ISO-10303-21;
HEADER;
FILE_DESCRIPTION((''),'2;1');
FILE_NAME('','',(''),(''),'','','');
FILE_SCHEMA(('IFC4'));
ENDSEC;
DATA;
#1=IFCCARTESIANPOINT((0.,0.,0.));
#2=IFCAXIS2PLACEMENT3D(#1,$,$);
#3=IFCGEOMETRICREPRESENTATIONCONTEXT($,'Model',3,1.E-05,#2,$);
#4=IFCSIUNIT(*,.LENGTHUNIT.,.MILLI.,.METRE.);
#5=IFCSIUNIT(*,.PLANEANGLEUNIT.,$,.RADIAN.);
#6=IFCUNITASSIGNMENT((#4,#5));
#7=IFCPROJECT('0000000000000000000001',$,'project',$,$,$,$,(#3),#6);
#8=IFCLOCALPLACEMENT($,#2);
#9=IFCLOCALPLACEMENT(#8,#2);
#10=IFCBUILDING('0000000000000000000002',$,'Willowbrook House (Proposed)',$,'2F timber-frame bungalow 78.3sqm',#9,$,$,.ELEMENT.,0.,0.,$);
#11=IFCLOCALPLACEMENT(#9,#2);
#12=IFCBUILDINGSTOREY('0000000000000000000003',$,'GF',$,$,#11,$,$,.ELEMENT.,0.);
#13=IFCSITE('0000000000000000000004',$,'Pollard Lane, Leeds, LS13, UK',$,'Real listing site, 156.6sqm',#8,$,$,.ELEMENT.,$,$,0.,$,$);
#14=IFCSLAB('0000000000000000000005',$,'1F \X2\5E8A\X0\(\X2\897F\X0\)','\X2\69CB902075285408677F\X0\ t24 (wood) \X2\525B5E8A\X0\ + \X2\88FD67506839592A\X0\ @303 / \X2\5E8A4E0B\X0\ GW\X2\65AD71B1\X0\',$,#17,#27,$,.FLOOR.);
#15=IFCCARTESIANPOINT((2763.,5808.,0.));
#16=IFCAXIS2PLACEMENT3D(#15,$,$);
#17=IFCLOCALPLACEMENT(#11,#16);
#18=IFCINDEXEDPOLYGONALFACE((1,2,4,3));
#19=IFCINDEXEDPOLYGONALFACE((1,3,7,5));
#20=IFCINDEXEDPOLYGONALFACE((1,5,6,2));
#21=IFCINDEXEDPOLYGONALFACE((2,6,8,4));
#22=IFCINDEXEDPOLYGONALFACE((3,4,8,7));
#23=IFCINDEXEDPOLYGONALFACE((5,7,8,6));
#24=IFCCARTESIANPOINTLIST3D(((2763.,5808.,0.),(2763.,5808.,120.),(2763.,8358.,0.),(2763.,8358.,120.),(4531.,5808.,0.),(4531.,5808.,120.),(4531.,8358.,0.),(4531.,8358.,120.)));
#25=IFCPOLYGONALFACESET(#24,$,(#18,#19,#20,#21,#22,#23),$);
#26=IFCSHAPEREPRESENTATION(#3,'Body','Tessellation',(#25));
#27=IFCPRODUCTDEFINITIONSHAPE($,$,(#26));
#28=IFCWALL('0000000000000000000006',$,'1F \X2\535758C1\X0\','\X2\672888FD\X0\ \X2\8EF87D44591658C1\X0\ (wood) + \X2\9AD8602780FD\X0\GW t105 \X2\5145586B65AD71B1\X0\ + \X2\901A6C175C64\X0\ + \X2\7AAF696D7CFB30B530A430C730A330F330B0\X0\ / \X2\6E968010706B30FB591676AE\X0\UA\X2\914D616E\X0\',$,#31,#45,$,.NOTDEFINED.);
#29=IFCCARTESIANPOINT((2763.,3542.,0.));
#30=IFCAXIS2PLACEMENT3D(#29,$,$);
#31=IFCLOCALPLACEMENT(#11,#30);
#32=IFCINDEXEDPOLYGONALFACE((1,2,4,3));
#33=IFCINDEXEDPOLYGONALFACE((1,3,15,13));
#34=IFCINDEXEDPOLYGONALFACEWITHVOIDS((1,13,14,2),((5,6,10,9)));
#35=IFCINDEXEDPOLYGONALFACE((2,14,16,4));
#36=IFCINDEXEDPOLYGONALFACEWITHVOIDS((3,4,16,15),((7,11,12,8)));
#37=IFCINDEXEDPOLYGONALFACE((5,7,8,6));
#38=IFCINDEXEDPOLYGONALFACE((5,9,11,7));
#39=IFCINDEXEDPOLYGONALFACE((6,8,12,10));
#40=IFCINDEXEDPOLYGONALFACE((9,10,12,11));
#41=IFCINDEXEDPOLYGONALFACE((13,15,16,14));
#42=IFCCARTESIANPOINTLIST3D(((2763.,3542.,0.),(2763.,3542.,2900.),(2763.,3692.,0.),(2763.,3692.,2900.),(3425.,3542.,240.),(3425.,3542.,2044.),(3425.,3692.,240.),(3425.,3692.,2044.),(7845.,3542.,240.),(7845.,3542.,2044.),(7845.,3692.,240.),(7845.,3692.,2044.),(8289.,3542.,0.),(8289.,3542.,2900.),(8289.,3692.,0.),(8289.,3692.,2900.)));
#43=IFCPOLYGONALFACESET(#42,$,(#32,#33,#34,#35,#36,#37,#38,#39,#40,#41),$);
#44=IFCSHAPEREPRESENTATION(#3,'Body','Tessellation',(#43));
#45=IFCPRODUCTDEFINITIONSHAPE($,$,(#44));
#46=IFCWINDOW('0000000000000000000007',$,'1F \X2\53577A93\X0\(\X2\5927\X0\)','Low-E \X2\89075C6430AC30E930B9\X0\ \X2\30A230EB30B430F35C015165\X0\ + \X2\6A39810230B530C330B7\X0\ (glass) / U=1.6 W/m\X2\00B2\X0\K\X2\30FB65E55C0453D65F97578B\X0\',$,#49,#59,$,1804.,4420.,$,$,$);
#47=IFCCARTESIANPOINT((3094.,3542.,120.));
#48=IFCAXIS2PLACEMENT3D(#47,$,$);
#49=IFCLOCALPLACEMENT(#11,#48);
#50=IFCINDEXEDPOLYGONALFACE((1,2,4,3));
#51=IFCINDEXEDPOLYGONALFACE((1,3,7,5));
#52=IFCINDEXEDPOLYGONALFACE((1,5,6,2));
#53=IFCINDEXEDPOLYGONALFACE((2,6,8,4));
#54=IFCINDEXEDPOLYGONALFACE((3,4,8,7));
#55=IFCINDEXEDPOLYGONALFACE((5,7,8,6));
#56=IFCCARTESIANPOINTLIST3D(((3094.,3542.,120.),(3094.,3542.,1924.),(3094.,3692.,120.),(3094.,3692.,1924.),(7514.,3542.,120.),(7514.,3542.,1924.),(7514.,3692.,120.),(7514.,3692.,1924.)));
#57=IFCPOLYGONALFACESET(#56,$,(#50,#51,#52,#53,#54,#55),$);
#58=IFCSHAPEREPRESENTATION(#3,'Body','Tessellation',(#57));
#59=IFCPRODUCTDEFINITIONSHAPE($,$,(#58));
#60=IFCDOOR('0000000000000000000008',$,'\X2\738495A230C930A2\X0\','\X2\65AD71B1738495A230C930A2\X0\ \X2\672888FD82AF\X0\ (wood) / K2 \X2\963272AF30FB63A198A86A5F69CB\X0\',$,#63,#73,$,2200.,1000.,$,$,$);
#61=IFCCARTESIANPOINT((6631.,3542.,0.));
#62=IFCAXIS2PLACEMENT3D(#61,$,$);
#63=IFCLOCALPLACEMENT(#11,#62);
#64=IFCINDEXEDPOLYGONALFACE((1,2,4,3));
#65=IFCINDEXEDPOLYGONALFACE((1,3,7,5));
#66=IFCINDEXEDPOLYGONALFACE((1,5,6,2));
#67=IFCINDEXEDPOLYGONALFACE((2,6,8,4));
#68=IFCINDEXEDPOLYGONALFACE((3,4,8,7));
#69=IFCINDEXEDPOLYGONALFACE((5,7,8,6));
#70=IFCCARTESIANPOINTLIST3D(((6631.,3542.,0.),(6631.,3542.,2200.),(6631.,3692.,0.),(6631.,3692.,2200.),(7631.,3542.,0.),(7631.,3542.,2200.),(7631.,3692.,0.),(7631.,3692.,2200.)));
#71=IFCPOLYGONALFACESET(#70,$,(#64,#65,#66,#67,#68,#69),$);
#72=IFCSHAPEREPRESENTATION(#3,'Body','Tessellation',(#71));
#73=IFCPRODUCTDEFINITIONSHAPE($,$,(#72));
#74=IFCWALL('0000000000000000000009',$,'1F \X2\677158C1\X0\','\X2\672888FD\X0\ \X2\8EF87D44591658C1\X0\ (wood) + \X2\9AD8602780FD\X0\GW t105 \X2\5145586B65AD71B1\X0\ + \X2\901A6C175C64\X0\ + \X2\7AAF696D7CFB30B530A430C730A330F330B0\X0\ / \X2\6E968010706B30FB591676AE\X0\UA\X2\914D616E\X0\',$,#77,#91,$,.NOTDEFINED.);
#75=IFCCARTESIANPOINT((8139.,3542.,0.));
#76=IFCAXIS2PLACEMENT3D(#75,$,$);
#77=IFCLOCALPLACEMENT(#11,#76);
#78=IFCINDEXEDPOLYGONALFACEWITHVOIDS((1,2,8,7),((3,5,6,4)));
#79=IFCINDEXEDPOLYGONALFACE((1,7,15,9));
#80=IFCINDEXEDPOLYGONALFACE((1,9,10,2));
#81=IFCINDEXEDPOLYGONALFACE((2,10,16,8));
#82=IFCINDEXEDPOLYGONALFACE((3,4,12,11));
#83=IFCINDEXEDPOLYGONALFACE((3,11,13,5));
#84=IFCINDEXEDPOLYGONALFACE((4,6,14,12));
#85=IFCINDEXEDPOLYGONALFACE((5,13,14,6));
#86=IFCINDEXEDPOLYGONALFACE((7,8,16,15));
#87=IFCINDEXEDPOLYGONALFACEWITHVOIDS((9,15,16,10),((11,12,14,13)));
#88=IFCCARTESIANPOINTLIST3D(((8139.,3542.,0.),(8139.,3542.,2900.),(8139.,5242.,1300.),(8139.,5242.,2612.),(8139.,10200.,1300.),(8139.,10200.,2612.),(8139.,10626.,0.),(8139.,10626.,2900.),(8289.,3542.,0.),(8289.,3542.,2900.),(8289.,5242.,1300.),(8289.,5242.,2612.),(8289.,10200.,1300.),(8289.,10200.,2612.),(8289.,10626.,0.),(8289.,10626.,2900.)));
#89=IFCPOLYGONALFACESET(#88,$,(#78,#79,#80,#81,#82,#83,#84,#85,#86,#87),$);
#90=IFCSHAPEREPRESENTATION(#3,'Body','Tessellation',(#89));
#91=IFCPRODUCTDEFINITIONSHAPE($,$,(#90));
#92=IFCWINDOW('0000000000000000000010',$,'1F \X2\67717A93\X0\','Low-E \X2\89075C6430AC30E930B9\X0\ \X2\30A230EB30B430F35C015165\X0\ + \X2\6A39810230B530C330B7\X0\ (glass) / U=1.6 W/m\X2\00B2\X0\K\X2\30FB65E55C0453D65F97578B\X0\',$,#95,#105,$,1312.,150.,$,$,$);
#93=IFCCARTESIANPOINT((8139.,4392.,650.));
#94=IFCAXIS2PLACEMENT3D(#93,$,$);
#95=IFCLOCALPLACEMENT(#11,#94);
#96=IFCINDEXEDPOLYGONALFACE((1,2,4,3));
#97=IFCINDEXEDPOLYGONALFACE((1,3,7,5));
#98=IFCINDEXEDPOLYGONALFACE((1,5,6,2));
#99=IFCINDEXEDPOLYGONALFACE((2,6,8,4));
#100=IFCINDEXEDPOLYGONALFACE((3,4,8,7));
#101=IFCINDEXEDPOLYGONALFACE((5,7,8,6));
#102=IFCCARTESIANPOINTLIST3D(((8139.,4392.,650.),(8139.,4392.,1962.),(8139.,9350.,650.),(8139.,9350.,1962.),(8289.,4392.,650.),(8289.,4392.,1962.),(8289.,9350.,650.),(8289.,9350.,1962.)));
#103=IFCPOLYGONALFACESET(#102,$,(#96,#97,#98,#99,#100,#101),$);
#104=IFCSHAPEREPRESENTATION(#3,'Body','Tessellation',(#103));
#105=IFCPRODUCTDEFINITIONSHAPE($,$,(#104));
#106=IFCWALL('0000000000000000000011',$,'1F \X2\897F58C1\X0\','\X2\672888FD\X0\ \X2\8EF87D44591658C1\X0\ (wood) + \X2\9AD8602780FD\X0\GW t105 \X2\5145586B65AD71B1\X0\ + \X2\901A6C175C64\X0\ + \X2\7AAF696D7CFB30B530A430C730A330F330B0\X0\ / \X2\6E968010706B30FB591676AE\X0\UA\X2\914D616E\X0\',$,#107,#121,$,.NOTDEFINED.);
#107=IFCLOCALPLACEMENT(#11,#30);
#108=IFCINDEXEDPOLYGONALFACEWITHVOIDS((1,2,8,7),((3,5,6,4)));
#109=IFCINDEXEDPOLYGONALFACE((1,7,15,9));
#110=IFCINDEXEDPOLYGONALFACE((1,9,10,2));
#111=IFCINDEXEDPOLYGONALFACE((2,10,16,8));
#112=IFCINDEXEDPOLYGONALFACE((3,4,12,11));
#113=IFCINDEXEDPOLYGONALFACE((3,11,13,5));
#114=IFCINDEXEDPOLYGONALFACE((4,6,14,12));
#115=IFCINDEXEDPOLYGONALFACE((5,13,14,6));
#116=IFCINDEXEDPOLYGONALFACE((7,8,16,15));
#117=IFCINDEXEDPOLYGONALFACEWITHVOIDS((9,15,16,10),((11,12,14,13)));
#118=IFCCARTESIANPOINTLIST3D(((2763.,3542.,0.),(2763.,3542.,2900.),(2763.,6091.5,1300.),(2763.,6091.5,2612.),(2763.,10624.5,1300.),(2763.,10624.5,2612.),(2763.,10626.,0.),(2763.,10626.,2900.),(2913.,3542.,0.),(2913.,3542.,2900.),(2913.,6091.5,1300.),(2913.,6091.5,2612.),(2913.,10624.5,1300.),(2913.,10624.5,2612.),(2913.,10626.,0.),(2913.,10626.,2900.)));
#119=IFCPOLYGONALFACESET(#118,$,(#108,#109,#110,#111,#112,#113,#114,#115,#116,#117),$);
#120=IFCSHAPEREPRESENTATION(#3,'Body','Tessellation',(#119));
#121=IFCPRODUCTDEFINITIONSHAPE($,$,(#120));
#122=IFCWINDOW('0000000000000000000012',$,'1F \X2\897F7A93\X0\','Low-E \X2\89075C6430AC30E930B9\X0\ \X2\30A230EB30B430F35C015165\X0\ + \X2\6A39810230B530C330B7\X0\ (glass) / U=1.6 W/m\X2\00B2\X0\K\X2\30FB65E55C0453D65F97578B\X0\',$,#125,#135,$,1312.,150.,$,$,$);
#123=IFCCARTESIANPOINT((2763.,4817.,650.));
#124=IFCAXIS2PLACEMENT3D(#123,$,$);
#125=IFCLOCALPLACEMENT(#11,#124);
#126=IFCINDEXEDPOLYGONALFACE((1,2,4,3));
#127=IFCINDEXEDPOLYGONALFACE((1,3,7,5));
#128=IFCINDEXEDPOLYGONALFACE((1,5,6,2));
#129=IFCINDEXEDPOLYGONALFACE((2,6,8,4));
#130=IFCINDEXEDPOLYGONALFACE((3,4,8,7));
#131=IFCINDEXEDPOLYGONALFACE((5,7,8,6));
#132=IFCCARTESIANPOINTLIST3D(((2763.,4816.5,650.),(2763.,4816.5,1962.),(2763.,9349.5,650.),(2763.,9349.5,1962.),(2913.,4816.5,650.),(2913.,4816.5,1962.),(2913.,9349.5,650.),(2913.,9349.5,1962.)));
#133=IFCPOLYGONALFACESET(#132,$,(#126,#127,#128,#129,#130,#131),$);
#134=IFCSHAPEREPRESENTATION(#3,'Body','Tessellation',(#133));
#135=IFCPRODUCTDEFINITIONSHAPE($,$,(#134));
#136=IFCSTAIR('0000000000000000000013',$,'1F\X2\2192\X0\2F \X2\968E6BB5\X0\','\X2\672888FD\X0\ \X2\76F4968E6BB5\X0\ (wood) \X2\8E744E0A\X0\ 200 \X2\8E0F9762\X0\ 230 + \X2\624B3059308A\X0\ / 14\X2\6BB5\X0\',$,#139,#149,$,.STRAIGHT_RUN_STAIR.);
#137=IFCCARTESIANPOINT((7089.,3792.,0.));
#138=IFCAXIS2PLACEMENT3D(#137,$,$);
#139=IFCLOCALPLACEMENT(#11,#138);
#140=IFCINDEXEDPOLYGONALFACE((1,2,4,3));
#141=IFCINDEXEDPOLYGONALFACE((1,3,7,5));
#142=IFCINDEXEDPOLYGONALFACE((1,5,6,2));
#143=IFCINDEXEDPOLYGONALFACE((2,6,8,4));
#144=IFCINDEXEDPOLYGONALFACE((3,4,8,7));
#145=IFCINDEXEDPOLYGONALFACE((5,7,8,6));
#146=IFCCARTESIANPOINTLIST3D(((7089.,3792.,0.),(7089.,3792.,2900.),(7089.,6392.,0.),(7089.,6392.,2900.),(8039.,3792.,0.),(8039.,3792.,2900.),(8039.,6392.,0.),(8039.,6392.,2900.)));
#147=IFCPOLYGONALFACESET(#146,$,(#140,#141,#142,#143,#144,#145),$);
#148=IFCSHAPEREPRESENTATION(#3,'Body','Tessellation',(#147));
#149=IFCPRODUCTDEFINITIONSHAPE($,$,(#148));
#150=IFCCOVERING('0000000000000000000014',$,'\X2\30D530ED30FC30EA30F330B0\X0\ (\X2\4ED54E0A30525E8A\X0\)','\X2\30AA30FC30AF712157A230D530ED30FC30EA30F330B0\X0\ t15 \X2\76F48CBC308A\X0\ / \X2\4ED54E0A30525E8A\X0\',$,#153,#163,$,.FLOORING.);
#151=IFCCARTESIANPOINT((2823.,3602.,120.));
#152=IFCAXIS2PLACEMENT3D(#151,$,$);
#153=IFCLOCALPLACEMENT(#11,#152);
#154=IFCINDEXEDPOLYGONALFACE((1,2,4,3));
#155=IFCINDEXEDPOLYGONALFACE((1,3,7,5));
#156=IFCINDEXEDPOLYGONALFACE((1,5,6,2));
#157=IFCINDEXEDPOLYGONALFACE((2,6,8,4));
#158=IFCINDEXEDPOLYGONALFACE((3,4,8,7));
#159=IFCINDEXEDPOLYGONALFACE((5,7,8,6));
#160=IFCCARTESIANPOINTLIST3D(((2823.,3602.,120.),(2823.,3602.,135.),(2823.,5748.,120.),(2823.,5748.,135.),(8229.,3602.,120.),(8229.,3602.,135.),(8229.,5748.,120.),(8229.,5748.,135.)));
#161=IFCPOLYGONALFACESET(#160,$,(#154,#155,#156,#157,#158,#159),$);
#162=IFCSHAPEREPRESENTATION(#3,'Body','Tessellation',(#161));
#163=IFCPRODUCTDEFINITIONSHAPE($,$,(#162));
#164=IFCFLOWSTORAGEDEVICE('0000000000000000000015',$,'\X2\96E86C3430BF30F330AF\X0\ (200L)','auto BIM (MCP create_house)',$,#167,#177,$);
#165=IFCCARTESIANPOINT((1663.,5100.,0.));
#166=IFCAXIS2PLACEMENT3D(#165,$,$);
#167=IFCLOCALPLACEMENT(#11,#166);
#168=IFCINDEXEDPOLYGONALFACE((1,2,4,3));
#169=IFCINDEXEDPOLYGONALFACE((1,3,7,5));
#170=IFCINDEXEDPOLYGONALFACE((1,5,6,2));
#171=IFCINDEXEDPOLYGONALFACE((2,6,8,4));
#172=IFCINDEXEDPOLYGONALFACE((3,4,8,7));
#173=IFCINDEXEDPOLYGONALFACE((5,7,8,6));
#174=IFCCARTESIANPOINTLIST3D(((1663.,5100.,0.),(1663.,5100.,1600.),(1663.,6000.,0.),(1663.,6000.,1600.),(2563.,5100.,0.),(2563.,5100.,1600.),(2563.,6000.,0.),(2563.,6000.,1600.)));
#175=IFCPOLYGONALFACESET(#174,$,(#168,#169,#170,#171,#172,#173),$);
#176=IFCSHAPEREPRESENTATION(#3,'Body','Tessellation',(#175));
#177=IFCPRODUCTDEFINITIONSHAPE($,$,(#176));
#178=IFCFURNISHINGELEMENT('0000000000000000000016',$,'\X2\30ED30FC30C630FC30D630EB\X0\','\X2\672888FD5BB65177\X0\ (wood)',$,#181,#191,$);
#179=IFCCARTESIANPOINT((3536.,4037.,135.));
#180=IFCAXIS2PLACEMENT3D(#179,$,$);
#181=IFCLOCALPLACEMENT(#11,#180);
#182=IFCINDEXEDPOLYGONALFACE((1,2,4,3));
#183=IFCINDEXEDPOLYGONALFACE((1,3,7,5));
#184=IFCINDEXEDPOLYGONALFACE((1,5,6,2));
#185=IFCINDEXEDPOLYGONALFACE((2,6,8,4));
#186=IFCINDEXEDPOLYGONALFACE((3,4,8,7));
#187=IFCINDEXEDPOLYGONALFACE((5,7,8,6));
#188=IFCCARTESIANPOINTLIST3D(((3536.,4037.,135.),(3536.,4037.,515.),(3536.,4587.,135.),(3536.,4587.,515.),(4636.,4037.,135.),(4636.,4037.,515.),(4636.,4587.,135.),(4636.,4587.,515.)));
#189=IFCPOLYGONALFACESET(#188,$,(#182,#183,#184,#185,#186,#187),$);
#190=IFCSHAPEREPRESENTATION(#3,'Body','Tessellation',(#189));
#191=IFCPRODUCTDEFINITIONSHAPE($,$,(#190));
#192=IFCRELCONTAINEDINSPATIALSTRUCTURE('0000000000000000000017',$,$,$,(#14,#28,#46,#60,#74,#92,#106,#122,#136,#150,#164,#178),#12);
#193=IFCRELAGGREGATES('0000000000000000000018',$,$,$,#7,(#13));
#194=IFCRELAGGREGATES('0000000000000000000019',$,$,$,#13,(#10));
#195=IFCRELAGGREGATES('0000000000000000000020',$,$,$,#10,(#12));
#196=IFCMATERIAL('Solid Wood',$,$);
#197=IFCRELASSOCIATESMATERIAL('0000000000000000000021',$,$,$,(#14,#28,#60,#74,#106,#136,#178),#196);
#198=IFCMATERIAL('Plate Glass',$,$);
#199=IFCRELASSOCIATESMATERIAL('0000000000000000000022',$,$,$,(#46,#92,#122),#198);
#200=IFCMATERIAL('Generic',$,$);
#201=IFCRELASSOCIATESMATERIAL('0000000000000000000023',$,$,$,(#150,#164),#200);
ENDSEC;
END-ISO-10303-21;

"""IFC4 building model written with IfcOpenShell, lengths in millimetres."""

from ifc_helpers import new_model, si_unit, frame, frame_2d, origin, place, context, project, spatial, rectangle, extrude, material, element, fill, save


model = new_model("IFC4")

# Units and contexts
model_context = context("Model", 3, precision=1e-05, world=origin())
ifc_project = project(units=[si_unit("LENGTHUNIT", "METRE", prefix="MILLI"), si_unit("PLANEANGLEUNIT", "RADIAN")], contexts=[model_context])

# Site, building, storey
site_placement = place(None, origin())
site = spatial("IfcSite", under=ifc_project, at=site_placement, Name="Pollard Lane, Leeds, LS13, UK", ObjectType="Real listing site, 156.6sqm", CompositionType="ELEMENT", RefElevation=0.0)
building_placement = place(site_placement, origin())
building = spatial("IfcBuilding", under=site, at=building_placement, Name="Willowbrook House (Proposed)", ObjectType="2F timber-frame bungalow 78.3sqm", CompositionType="ELEMENT", ElevationOfRefHeight=0.0, ElevationOfTerrain=0.0)
storey_placement = place(building_placement, origin())
storey = spatial("IfcBuildingStorey", under=building, at=storey_placement, Name="GF", CompositionType="ELEMENT", Elevation=0.0)

# Slab
ifc_material_1 = material(Name="Solid Wood")
slab_1_placement = place(storey_placement, frame((2763.0, 5808.0, 0.0)))
element("IfcSlab", 1, at=slab_1_placement, inside=storey, material=ifc_material_1, Name="1F 床(西)", Description="構造用合板 t24 (wood) 剛床 + 製材根太 @303 / 床下 GW断熱", PredefinedType="FLOOR", context=model_context, shape_type="SweptSolid", body=[
    extrude(rectangle(XDim=1768.0, YDim=2550.0, at=frame_2d((884.0, 1275.0))), frame((2763.0, 5808.0, 0.0)), (0.0, 0.0, 1.0), 120.0),
])

# Wall, openings, window, door
wall_1_placement = place(storey_placement, frame((2763.0, 3542.0, 0.0)))
wall_1 = element("IfcWall", 2, at=wall_1_placement, inside=storey, material=ifc_material_1, Name="1F 南壁", Description="木製 軸組外壁 (wood) + 高性能GW t105 充填断熱 + 通気層 + 窯業系サイディング / 準耐火・外皮UA配慮", PredefinedType="NOTDEFINED", context=model_context, shape_type="SweptSolid", body=[
    extrude(rectangle(XDim=5526.0, YDim=150.0, at=frame_2d((2763.0, 75.0))), frame((2763.0, 3542.0, 0.0)), (0.0, 0.0, 1.0), 2900.0),
])
opening_1_placement = place(storey_placement, frame((3094.0, 3542.0, 120.0)))
opening_1 = element("IfcOpeningElement", 3, at=opening_1_placement, cuts=wall_1, PredefinedType="NOTDEFINED", context=model_context, shape_type="SweptSolid", body=[
    extrude(rectangle(XDim=4420.0, YDim=150.0, at=frame_2d((2210.0, 75.0))), frame((3094.0, 3542.0, 120.0)), (0.0, 0.0, 1.0), 1804.0),
])
opening_2_placement = place(storey_placement, frame((6631.0, 3542.0, 0.0)))
opening_2 = element("IfcOpeningElement", 4, at=opening_2_placement, cuts=wall_1, PredefinedType="NOTDEFINED", context=model_context, shape_type="SweptSolid", body=[
    extrude(rectangle(XDim=1000.0, YDim=150.0, at=frame_2d((500.0, 75.0))), frame((6631.0, 3542.0, 0.0)), (0.0, 0.0, 1.0), 2200.0),
])
ifc_material_2 = material(Name="Plate Glass")
window_1_placement = place(storey_placement, frame((3094.0, 3542.0, 120.0)))
window_1 = element("IfcWindow", 5, at=window_1_placement, inside=storey, material=ifc_material_2, Name="1F 南窓(大)", Description="Low-E 複層ガラス アルゴン封入 + 樹脂サッシ (glass) / U=1.6 W/m²K・日射取得型", OverallHeight=1804.0, OverallWidth=4420.0, context=model_context, shape_type="SweptSolid", body=[
    extrude(rectangle(XDim=4420.0, YDim=150.0, at=frame_2d((2210.0, 75.0))), frame((3094.0, 3542.0, 120.0)), (0.0, 0.0, 1.0), 1804.0),
])
fill(opening_1, window_1)
door_placement = place(storey_placement, frame((6631.0, 3542.0, 0.0)))
door = element("IfcDoor", 6, at=door_placement, inside=storey, material=ifc_material_1, Name="玄関ドア", Description="断熱玄関ドア 木製芯 (wood) / K2 防犯・採風機構", OverallHeight=2200.0, OverallWidth=1000.0, context=model_context, shape_type="SweptSolid", body=[
    extrude(rectangle(XDim=1000.0, YDim=150.0, at=frame_2d((500.0, 75.0))), frame((6631.0, 3542.0, 0.0)), (0.0, 0.0, 1.0), 2200.0),
])
fill(opening_2, door)

# Walls, openings, windows
wall_2_placement = place(storey_placement, frame((8139.0, 3542.0, 0.0)))
wall_2 = element("IfcWall", 7, at=wall_2_placement, inside=storey, material=ifc_material_1, Name="1F 東壁", Description="木製 軸組外壁 (wood) + 高性能GW t105 充填断熱 + 通気層 + 窯業系サイディング / 準耐火・外皮UA配慮", PredefinedType="NOTDEFINED", context=model_context, shape_type="SweptSolid", body=[
    extrude(rectangle(XDim=150.0, YDim=7084.0, at=frame_2d((75.0, 3542.0))), frame((8139.0, 3542.0, 0.0)), (0.0, 0.0, 1.0), 2900.0),
])
opening_3_placement = place(storey_placement, frame((8139.0, 4392.0, 650.0)))
opening_3 = element("IfcOpeningElement", 8, at=opening_3_placement, cuts=wall_2, PredefinedType="NOTDEFINED", context=model_context, shape_type="SweptSolid", body=[
    extrude(rectangle(XDim=150.0, YDim=4958.0, at=frame_2d((75.0, 2479.0))), frame((8139.0, 4392.0, 650.0)), (0.0, 0.0, 1.0), 1312.0),
])
window_2_placement = place(storey_placement, frame((8139.0, 4392.0, 650.0)))
window_2 = element("IfcWindow", 9, at=window_2_placement, inside=storey, material=ifc_material_2, Name="1F 東窓", Description="Low-E 複層ガラス アルゴン封入 + 樹脂サッシ (glass) / U=1.6 W/m²K・日射取得型", OverallHeight=1312.0, OverallWidth=150.0, context=model_context, shape_type="SweptSolid", body=[
    extrude(rectangle(XDim=150.0, YDim=4958.0, at=frame_2d((75.0, 2479.0))), frame((8139.0, 4392.0, 650.0)), (0.0, 0.0, 1.0), 1312.0),
])
fill(opening_3, window_2)
wall_3_placement = place(storey_placement, frame((2763.0, 3542.0, 0.0)))
wall_3 = element("IfcWall", 10, at=wall_3_placement, inside=storey, material=ifc_material_1, Name="1F 西壁", Description="木製 軸組外壁 (wood) + 高性能GW t105 充填断熱 + 通気層 + 窯業系サイディング / 準耐火・外皮UA配慮", PredefinedType="NOTDEFINED", context=model_context, shape_type="SweptSolid", body=[
    extrude(rectangle(XDim=150.0, YDim=7084.0, at=frame_2d((75.0, 3542.0))), frame((2763.0, 3542.0, 0.0)), (0.0, 0.0, 1.0), 2900.0),
])
opening_4_placement = place(storey_placement, frame((2763.0, 4817.0, 650.0)))
opening_4 = element("IfcOpeningElement", 11, at=opening_4_placement, cuts=wall_3, PredefinedType="NOTDEFINED", context=model_context, shape_type="SweptSolid", body=[
    extrude(rectangle(XDim=150.0, YDim=4533.0, at=frame_2d((75.0, 2266.0))), frame((2763.0, 4817.0, 650.0)), (0.0, 0.0, 1.0), 1312.0),
])
window_3_placement = place(storey_placement, frame((2763.0, 4817.0, 650.0)))
window_3 = element("IfcWindow", 12, at=window_3_placement, inside=storey, material=ifc_material_2, Name="1F 西窓", Description="Low-E 複層ガラス アルゴン封入 + 樹脂サッシ (glass) / U=1.6 W/m²K・日射取得型", OverallHeight=1312.0, OverallWidth=150.0, context=model_context, shape_type="SweptSolid", body=[
    extrude(rectangle(XDim=150.0, YDim=4533.0, at=frame_2d((75.0, 2266.0))), frame((2763.0, 4817.0, 650.0)), (0.0, 0.0, 1.0), 1312.0),
])
fill(opening_4, window_3)

# Stair
stair_placement = place(storey_placement, frame((7089.0, 3792.0, 0.0)))
element("IfcStair", 13, at=stair_placement, inside=storey, material=ifc_material_1, Name="1F→2F 階段", Description="木製 直階段 (wood) 蹴上 200 踏面 230 + 手すり / 14段", PredefinedType="STRAIGHT_RUN_STAIR", context=model_context, shape_type="SweptSolid", body=[
    extrude(rectangle(XDim=950.0, YDim=2600.0, at=frame_2d((475.0, 1300.0))), frame((7089.0, 3792.0, 0.0)), (0.0, 0.0, 1.0), 2900.0),
])

# Covering
ifc_material_3 = material(Name="Generic")
covering_placement = place(storey_placement, frame((2823.0, 3602.0, 120.0)))
element("IfcCovering", 14, at=covering_placement, inside=storey, material=ifc_material_3, Name="フローリング (仕上げ床)", Description="オーク無垢フローリング t15 直貼り / 仕上げ床", PredefinedType="FLOORING", context=model_context, shape_type="SweptSolid", body=[
    extrude(rectangle(XDim=5406.0, YDim=2146.0, at=frame_2d((2703.0, 1073.0))), frame((2823.0, 3602.0, 120.0)), (0.0, 0.0, 1.0), 15.0),
])

# Flow storage device
flow_storage_device_placement = place(storey_placement, frame((1663.0, 5100.0, 0.0)))
element("IfcFlowStorageDevice", 15, at=flow_storage_device_placement, inside=storey, material=ifc_material_3, Name="雨水タンク (200L)", Description="auto BIM (MCP create_house)", context=model_context, shape_type="SweptSolid", body=[
    extrude(rectangle(XDim=900.0, YDim=900.0, at=frame_2d((450.0, 450.0))), frame((1663.0, 5100.0, 0.0)), (0.0, 0.0, 1.0), 1600.0),
])

# Furnishing element
furnishing_1_placement = place(storey_placement, frame((3536.0, 4037.0, 135.0)))
element("IfcFurnishingElement", 16, at=furnishing_1_placement, inside=storey, material=ifc_material_1, Name="ローテーブル", Description="木製家具 (wood)", context=model_context, shape_type="SweptSolid", body=[
    extrude(rectangle(XDim=1100.0, YDim=550.0, at=frame_2d((550.0, 275.0))), frame((3536.0, 4037.0, 135.0)), (0.0, 0.0, 1.0), 380.0),
])

save(model, "model.ifc")
